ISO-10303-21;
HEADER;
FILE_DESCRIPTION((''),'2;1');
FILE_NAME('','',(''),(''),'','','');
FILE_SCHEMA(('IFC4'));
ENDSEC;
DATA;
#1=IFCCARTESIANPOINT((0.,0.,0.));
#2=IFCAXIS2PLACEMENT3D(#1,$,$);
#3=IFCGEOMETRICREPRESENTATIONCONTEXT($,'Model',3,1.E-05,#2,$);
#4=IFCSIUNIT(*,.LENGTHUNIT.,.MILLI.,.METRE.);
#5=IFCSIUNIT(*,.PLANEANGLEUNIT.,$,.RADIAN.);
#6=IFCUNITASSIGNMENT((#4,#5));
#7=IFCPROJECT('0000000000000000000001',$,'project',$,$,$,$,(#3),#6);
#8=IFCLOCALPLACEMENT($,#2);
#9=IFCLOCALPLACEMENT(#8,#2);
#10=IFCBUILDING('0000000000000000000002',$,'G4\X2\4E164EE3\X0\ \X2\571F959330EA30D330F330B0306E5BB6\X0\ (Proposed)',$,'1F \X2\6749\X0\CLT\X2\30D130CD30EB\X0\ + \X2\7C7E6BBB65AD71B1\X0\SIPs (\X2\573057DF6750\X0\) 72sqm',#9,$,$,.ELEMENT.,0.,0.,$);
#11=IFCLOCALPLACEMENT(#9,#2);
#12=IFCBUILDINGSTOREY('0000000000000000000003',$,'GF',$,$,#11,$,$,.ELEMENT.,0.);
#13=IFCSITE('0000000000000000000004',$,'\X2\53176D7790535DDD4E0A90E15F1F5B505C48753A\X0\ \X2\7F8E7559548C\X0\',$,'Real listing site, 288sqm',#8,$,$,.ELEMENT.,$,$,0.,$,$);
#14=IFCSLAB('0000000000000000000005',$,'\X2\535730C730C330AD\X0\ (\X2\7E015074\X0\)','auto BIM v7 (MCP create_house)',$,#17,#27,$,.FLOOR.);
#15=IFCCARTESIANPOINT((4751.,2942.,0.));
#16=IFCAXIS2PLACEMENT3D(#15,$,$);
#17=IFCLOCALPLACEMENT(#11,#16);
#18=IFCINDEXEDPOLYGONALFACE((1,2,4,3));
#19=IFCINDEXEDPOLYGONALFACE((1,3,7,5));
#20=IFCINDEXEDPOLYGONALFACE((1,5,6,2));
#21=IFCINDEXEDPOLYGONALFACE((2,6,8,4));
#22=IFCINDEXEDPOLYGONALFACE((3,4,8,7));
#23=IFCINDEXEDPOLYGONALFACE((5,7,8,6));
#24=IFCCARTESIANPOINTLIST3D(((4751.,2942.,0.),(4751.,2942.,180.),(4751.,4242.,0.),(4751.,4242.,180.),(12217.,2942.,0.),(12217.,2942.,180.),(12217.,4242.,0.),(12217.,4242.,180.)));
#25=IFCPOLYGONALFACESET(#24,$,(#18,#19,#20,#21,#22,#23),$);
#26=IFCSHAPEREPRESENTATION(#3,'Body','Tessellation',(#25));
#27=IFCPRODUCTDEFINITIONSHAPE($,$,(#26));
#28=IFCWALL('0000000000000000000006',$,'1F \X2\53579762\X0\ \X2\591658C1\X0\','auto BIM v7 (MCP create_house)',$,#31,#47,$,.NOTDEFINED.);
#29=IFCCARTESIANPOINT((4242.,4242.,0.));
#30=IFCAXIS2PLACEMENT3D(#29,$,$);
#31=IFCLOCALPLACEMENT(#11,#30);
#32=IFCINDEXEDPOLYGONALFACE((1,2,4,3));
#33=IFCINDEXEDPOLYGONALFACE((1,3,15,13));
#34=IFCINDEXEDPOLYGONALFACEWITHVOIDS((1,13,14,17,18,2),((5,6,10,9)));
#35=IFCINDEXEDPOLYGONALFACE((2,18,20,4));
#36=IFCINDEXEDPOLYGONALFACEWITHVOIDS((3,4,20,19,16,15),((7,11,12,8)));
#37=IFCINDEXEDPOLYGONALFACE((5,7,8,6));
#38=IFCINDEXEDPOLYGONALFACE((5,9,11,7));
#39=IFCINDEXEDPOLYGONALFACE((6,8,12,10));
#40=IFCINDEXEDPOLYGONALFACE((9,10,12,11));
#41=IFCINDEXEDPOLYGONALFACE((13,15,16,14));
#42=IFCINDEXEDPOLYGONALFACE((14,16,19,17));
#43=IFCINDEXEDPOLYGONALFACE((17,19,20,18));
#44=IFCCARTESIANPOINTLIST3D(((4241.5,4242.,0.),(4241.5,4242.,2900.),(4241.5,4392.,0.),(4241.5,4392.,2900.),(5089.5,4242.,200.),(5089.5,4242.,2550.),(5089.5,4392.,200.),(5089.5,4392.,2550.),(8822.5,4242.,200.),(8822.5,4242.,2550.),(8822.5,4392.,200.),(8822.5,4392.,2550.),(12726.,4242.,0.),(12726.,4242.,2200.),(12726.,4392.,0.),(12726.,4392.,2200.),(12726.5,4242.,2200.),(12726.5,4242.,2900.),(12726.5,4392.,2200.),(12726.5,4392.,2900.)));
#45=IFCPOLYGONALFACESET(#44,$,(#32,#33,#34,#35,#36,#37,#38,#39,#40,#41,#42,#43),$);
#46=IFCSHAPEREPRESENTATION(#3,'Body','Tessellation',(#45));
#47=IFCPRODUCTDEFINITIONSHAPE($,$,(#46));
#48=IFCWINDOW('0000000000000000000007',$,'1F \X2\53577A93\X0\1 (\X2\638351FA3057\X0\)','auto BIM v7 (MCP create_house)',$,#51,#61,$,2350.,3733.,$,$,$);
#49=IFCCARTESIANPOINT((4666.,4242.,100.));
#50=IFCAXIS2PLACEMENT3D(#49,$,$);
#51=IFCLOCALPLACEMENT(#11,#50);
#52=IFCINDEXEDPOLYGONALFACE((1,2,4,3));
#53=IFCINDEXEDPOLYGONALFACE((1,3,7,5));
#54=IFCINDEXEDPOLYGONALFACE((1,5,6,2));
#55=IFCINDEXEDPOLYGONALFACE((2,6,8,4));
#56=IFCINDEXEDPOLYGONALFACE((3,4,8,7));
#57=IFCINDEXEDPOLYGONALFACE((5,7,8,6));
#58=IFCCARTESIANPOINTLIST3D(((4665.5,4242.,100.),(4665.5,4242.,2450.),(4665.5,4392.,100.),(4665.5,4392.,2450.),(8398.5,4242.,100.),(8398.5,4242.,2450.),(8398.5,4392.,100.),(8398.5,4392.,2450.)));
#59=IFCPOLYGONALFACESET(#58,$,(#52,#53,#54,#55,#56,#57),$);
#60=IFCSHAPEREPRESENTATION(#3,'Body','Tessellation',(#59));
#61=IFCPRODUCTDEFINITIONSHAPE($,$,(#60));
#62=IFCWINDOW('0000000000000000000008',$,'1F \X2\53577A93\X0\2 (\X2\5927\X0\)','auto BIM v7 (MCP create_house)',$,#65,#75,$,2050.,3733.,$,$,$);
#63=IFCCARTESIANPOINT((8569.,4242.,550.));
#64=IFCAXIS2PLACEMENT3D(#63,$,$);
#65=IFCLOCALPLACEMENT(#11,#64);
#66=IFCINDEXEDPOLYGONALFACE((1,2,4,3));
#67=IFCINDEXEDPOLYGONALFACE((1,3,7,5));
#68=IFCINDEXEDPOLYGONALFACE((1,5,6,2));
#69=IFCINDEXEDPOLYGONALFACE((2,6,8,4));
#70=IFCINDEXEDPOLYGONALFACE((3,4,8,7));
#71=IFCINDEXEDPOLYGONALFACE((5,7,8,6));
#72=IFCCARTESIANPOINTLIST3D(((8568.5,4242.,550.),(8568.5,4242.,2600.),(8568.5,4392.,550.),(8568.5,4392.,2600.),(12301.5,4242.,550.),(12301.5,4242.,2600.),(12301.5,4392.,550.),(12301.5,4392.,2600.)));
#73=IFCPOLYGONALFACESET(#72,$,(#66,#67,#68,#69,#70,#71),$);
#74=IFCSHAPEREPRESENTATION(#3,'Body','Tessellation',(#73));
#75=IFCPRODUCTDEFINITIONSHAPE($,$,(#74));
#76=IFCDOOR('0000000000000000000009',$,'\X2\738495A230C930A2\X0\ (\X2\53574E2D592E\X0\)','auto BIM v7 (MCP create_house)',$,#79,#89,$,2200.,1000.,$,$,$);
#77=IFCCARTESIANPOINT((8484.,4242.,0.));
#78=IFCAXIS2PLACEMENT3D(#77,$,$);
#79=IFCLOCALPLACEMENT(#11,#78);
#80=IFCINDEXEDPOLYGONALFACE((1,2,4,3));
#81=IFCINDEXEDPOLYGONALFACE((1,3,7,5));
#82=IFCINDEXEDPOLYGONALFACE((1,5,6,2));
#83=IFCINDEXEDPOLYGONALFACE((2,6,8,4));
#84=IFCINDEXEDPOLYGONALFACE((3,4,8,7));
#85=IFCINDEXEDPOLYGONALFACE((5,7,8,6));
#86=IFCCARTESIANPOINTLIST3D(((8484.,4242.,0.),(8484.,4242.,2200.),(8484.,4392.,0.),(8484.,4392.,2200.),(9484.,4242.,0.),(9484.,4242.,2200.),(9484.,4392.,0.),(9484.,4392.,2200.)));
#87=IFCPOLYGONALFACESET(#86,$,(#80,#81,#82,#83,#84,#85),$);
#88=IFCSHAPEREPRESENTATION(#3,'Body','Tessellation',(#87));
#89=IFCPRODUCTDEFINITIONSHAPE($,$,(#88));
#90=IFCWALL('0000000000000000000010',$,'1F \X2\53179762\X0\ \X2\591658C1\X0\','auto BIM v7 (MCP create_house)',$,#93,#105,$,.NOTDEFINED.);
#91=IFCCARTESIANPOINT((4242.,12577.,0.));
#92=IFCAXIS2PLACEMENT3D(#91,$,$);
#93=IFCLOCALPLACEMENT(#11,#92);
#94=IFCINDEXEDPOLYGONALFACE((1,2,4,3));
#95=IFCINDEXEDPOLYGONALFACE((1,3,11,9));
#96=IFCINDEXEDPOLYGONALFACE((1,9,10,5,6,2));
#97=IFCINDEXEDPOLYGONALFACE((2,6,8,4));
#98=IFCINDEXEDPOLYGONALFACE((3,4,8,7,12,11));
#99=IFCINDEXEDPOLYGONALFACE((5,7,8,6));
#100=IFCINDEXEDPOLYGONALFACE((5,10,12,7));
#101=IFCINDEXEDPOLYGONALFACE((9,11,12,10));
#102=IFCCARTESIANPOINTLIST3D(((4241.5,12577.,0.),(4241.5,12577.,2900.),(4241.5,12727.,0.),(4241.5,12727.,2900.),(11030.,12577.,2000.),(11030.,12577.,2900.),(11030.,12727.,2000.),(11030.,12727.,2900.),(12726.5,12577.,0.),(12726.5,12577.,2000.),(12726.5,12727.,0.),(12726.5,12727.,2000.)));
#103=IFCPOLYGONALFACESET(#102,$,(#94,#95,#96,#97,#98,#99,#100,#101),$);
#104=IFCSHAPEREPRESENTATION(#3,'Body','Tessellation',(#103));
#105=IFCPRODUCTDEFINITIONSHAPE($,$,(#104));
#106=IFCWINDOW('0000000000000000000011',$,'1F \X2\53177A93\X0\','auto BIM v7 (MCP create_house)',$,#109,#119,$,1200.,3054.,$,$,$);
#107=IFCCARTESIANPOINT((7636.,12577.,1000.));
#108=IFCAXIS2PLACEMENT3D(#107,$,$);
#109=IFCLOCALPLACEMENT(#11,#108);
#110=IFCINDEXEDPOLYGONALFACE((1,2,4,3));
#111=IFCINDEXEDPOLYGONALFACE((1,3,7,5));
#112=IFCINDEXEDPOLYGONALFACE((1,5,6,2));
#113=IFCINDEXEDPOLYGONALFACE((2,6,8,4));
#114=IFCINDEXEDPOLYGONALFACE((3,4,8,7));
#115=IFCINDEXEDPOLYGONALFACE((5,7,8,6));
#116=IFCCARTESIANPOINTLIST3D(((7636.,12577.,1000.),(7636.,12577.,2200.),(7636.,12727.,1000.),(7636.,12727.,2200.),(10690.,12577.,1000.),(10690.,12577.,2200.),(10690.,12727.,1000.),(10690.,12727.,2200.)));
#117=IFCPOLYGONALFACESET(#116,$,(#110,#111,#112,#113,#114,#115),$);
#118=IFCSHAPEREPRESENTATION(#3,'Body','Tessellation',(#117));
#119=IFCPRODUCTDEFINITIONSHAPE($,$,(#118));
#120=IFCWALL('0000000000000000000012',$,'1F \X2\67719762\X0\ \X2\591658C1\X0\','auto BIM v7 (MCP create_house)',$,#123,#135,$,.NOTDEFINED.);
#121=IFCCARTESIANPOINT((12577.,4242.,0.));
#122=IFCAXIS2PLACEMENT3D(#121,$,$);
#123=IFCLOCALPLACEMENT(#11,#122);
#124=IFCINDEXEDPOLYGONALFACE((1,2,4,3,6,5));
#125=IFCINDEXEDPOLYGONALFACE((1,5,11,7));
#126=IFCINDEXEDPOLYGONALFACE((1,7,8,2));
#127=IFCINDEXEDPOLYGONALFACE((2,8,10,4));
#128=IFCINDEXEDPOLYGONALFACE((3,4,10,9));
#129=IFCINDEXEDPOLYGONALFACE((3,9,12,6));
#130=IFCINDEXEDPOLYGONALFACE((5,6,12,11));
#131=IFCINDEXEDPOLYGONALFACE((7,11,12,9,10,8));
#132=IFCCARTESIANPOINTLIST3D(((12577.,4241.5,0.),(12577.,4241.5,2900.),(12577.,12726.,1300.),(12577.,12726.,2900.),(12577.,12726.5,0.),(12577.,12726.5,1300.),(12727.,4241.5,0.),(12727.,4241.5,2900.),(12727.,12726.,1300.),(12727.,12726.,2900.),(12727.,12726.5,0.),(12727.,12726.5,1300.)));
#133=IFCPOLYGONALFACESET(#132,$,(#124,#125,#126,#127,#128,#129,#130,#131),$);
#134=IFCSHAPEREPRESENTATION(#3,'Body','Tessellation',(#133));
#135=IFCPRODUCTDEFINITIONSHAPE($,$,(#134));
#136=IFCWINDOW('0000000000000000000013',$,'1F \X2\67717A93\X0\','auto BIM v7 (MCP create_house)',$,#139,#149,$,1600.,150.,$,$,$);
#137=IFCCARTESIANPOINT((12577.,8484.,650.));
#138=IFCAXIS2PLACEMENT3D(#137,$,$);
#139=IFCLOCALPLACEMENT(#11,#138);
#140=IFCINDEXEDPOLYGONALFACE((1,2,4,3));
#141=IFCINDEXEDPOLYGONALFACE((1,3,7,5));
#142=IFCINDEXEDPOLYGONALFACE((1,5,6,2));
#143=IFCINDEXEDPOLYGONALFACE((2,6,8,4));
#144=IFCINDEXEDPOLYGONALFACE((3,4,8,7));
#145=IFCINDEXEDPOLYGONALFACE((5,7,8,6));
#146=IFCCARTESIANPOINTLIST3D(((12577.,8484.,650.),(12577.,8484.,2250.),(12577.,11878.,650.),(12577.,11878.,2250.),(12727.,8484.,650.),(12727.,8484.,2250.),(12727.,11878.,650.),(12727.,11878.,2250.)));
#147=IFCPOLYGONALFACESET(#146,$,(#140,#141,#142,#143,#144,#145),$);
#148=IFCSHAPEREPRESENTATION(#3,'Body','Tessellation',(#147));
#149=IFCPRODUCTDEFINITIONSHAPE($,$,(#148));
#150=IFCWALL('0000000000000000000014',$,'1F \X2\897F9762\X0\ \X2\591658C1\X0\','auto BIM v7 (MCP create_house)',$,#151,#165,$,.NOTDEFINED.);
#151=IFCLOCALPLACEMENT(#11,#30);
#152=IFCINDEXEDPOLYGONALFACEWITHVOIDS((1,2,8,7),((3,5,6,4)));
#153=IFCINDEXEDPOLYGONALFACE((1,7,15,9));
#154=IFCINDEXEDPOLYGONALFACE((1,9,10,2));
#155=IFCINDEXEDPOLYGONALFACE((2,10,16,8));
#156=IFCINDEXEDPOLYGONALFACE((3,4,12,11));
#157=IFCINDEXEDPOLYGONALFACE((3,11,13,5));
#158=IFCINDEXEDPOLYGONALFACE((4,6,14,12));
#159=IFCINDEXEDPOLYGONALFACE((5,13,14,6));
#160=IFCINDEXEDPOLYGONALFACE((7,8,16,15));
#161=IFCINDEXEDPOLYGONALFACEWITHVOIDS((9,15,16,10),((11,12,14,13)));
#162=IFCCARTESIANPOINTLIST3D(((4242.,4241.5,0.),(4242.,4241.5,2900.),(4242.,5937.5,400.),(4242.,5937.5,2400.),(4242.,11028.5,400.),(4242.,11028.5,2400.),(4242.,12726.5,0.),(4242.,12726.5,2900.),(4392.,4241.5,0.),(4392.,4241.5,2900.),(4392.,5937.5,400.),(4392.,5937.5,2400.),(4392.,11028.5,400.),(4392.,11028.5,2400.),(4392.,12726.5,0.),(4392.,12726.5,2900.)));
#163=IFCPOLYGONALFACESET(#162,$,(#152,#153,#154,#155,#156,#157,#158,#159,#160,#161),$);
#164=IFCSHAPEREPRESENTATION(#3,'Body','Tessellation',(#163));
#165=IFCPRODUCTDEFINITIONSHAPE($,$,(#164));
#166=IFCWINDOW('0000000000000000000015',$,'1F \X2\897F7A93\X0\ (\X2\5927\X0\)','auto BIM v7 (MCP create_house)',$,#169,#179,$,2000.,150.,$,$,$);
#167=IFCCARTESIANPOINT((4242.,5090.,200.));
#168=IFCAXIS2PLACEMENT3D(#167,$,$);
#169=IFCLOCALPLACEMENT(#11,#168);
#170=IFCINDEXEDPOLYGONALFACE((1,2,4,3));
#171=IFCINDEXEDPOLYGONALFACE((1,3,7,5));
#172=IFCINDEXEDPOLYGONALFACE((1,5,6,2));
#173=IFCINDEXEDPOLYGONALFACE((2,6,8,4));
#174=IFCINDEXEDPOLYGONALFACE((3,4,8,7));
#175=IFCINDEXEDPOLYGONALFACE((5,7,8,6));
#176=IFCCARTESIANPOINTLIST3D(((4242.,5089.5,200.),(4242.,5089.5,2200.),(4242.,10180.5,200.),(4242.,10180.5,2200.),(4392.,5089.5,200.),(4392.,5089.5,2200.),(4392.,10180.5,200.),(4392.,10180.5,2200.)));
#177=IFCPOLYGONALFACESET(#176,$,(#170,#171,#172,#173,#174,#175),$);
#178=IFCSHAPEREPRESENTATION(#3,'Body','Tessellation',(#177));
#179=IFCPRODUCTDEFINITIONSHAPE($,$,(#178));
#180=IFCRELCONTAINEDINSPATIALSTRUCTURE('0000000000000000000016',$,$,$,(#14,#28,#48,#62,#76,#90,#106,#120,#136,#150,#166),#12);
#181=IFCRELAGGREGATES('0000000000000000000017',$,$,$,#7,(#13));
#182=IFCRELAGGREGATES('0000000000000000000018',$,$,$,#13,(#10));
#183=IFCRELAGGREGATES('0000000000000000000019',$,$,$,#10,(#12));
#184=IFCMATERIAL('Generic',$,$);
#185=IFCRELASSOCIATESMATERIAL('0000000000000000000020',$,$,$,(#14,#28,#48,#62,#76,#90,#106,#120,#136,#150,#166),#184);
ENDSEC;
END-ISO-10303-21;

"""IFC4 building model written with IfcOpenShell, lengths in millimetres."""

from ifc_helpers import new_model, si_unit, frame, frame_2d, origin, place, context, project, spatial, rectangle, extrude, material, element, fill, save


model = new_model("IFC4")

# Units and contexts
model_context = context("Model", 3, precision=1e-05, world=origin())
ifc_project = project(units=[si_unit("LENGTHUNIT", "METRE", prefix="MILLI"), si_unit("PLANEANGLEUNIT", "RADIAN")], contexts=[model_context])

# Site, building, storey
site_placement = place(None, origin())
site = spatial("IfcSite", under=ifc_project, at=site_placement, Name="北海道川上郡弟子屈町 美留和", ObjectType="Real listing site, 288sqm", CompositionType="ELEMENT", RefElevation=0.0)
building_placement = place(site_placement, origin())
building = spatial("IfcBuilding", under=site, at=building_placement, Name="G4世代 土間リビングの家 (Proposed)", ObjectType="1F 杉CLTパネル + 籾殻断熱SIPs (地域材) 72sqm", CompositionType="ELEMENT", ElevationOfRefHeight=0.0, ElevationOfTerrain=0.0)
storey_placement = place(building_placement, origin())
storey = spatial("IfcBuildingStorey", under=building, at=storey_placement, Name="GF", CompositionType="ELEMENT", Elevation=0.0)

# Slab
ifc_material = material(Name="Generic")
slab_1_placement = place(storey_placement, frame((4751.0, 2942.0, 0.0)))
element("IfcSlab", 1, at=slab_1_placement, inside=storey, material=ifc_material, Name="南デッキ (縁側)", Description="auto BIM v7 (MCP create_house)", PredefinedType="FLOOR", context=model_context, shape_type="SweptSolid", body=[
    extrude(rectangle(XDim=7466.0, YDim=1300.0, at=frame_2d((3733.0, 650.0))), frame((4751.0, 2942.0, 0.0)), (0.0, 0.0, 1.0), 180.0),
])

# Wall, openings, windows, door
wall_1_placement = place(storey_placement, frame((4242.0, 4242.0, 0.0)))
wall_1 = element("IfcWall", 2, at=wall_1_placement, inside=storey, material=ifc_material, Name="1F 南面 外壁", Description="auto BIM v7 (MCP create_house)", PredefinedType="NOTDEFINED", context=model_context, shape_type="SweptSolid", body=[
    extrude(rectangle(XDim=8485.0, YDim=150.0, at=frame_2d((4242.0, 75.0))), frame((4242.0, 4242.0, 0.0)), (0.0, 0.0, 1.0), 2900.0),
])
opening_1_placement = place(storey_placement, frame((4666.0, 4242.0, 100.0)))
opening_1 = element("IfcOpeningElement", 3, at=opening_1_placement, cuts=wall_1, PredefinedType="NOTDEFINED", context=model_context, shape_type="SweptSolid", body=[
    extrude(rectangle(XDim=3733.0, YDim=150.0, at=frame_2d((1866.0, 75.0))), frame((4666.0, 4242.0, 100.0)), (0.0, 0.0, 1.0), 2350.0),
])
opening_2_placement = place(storey_placement, frame((8569.0, 4242.0, 550.0)))
opening_2 = element("IfcOpeningElement", 4, at=opening_2_placement, cuts=wall_1, PredefinedType="NOTDEFINED", context=model_context, shape_type="SweptSolid", body=[
    extrude(rectangle(XDim=3733.0, YDim=150.0, at=frame_2d((1866.0, 75.0))), frame((8569.0, 4242.0, 550.0)), (0.0, 0.0, 1.0), 2050.0),
])
opening_3_placement = place(storey_placement, frame((8484.0, 4242.0, 0.0)))
opening_3 = element("IfcOpeningElement", 5, at=opening_3_placement, cuts=wall_1, PredefinedType="NOTDEFINED", context=model_context, shape_type="SweptSolid", body=[
    extrude(rectangle(XDim=1000.0, YDim=150.0, at=frame_2d((500.0, 75.0))), frame((8484.0, 4242.0, 0.0)), (0.0, 0.0, 1.0), 2200.0),
])
window_1_placement = place(storey_placement, frame((4666.0, 4242.0, 100.0)))
window_1 = element("IfcWindow", 6, at=window_1_placement, inside=storey, material=ifc_material, Name="1F 南窓1 (掃出し)", Description="auto BIM v7 (MCP create_house)", OverallHeight=2350.0, OverallWidth=3733.0, context=model_context, shape_type="SweptSolid", body=[
    extrude(rectangle(XDim=3733.0, YDim=150.0, at=frame_2d((1866.0, 75.0))), frame((4666.0, 4242.0, 100.0)), (0.0, 0.0, 1.0), 2350.0),
])
fill(opening_1, window_1)
window_2_placement = place(storey_placement, frame((8569.0, 4242.0, 550.0)))
window_2 = element("IfcWindow", 7, at=window_2_placement, inside=storey, material=ifc_material, Name="1F 南窓2 (大)", Description="auto BIM v7 (MCP create_house)", OverallHeight=2050.0, OverallWidth=3733.0, context=model_context, shape_type="SweptSolid", body=[
    extrude(rectangle(XDim=3733.0, YDim=150.0, at=frame_2d((1866.0, 75.0))), frame((8569.0, 4242.0, 550.0)), (0.0, 0.0, 1.0), 2050.0),
])
fill(opening_2, window_2)
door_placement = place(storey_placement, frame((8484.0, 4242.0, 0.0)))
door = element("IfcDoor", 8, at=door_placement, inside=storey, material=ifc_material, Name="玄関ドア (南中央)", Description="auto BIM v7 (MCP create_house)", OverallHeight=2200.0, OverallWidth=1000.0, context=model_context, shape_type="SweptSolid", body=[
    extrude(rectangle(XDim=1000.0, YDim=150.0, at=frame_2d((500.0, 75.0))), frame((8484.0, 4242.0, 0.0)), (0.0, 0.0, 1.0), 2200.0),
])
fill(opening_3, door)

# Walls, openings, windows
wall_2_placement = place(storey_placement, frame((4242.0, 12577.0, 0.0)))
wall_2 = element("IfcWall", 9, at=wall_2_placement, inside=storey, material=ifc_material, Name="1F 北面 外壁", Description="auto BIM v7 (MCP create_house)", PredefinedType="NOTDEFINED", context=model_context, shape_type="SweptSolid", body=[
    extrude(rectangle(XDim=8485.0, YDim=150.0, at=frame_2d((4242.0, 75.0))), frame((4242.0, 12577.0, 0.0)), (0.0, 0.0, 1.0), 2900.0),
])
opening_4_placement = place(storey_placement, frame((7636.0, 12577.0, 1000.0)))
opening_4 = element("IfcOpeningElement", 10, at=opening_4_placement, cuts=wall_2, PredefinedType="NOTDEFINED", context=model_context, shape_type="SweptSolid", body=[
    extrude(rectangle(XDim=3054.0, YDim=150.0, at=frame_2d((1527.0, 75.0))), frame((7636.0, 12577.0, 1000.0)), (0.0, 0.0, 1.0), 1200.0),
])
window_3_placement = place(storey_placement, frame((7636.0, 12577.0, 1000.0)))
window_3 = element("IfcWindow", 11, at=window_3_placement, inside=storey, material=ifc_material, Name="1F 北窓", Description="auto BIM v7 (MCP create_house)", OverallHeight=1200.0, OverallWidth=3054.0, context=model_context, shape_type="SweptSolid", body=[
    extrude(rectangle(XDim=3054.0, YDim=150.0, at=frame_2d((1527.0, 75.0))), frame((7636.0, 12577.0, 1000.0)), (0.0, 0.0, 1.0), 1200.0),
])
fill(opening_4, window_3)
wall_3_placement = place(storey_placement, frame((12577.0, 4242.0, 0.0)))
wall_3 = element("IfcWall", 12, at=wall_3_placement, inside=storey, material=ifc_material, Name="1F 東面 外壁", Description="auto BIM v7 (MCP create_house)", PredefinedType="NOTDEFINED", context=model_context, shape_type="SweptSolid", body=[
    extrude(rectangle(XDim=150.0, YDim=8485.0, at=frame_2d((75.0, 4242.0))), frame((12577.0, 4242.0, 0.0)), (0.0, 0.0, 1.0), 2900.0),
])
opening_5_placement = place(storey_placement, frame((12577.0, 8484.0, 650.0)))
opening_5 = element("IfcOpeningElement", 13, at=opening_5_placement, cuts=wall_3, PredefinedType="NOTDEFINED", context=model_context, shape_type="SweptSolid", body=[
    extrude(rectangle(XDim=150.0, YDim=3394.0, at=frame_2d((75.0, 1697.0))), frame((12577.0, 8484.0, 650.0)), (0.0, 0.0, 1.0), 1600.0),
])
window_4_placement = place(storey_placement, frame((12577.0, 8484.0, 650.0)))
window_4 = element("IfcWindow", 14, at=window_4_placement, inside=storey, material=ifc_material, Name="1F 東窓", Description="auto BIM v7 (MCP create_house)", OverallHeight=1600.0, OverallWidth=150.0, context=model_context, shape_type="SweptSolid", body=[
    extrude(rectangle(XDim=150.0, YDim=3394.0, at=frame_2d((75.0, 1697.0))), frame((12577.0, 8484.0, 650.0)), (0.0, 0.0, 1.0), 1600.0),
])
fill(opening_5, window_4)
wall_4_placement = place(storey_placement, frame((4242.0, 4242.0, 0.0)))
wall_4 = element("IfcWall", 15, at=wall_4_placement, inside=storey, material=ifc_material, Name="1F 西面 外壁", Description="auto BIM v7 (MCP create_house)", PredefinedType="NOTDEFINED", context=model_context, shape_type="SweptSolid", body=[
    extrude(rectangle(XDim=150.0, YDim=8485.0, at=frame_2d((75.0, 4242.0))), frame((4242.0, 4242.0, 0.0)), (0.0, 0.0, 1.0), 2900.0),
])
opening_6_placement = place(storey_placement, frame((4242.0, 5090.0, 200.0)))
opening_6 = element("IfcOpeningElement", 16, at=opening_6_placement, cuts=wall_4, PredefinedType="NOTDEFINED", context=model_context, shape_type="SweptSolid", body=[
    extrude(rectangle(XDim=150.0, YDim=5091.0, at=frame_2d((75.0, 2545.0))), frame((4242.0, 5090.0, 200.0)), (0.0, 0.0, 1.0), 2000.0),
])
window_5_placement = place(storey_placement, frame((4242.0, 5090.0, 200.0)))
window_5 = element("IfcWindow", 17, at=window_5_placement, inside=storey, material=ifc_material, Name="1F 西窓 (大)", Description="auto BIM v7 (MCP create_house)", OverallHeight=2000.0, OverallWidth=150.0, context=model_context, shape_type="SweptSolid", body=[
    extrude(rectangle(XDim=150.0, YDim=5091.0, at=frame_2d((75.0, 2545.0))), frame((4242.0, 5090.0, 200.0)), (0.0, 0.0, 1.0), 2000.0),
])
fill(opening_6, window_5)

save(model, "model.ifc")
